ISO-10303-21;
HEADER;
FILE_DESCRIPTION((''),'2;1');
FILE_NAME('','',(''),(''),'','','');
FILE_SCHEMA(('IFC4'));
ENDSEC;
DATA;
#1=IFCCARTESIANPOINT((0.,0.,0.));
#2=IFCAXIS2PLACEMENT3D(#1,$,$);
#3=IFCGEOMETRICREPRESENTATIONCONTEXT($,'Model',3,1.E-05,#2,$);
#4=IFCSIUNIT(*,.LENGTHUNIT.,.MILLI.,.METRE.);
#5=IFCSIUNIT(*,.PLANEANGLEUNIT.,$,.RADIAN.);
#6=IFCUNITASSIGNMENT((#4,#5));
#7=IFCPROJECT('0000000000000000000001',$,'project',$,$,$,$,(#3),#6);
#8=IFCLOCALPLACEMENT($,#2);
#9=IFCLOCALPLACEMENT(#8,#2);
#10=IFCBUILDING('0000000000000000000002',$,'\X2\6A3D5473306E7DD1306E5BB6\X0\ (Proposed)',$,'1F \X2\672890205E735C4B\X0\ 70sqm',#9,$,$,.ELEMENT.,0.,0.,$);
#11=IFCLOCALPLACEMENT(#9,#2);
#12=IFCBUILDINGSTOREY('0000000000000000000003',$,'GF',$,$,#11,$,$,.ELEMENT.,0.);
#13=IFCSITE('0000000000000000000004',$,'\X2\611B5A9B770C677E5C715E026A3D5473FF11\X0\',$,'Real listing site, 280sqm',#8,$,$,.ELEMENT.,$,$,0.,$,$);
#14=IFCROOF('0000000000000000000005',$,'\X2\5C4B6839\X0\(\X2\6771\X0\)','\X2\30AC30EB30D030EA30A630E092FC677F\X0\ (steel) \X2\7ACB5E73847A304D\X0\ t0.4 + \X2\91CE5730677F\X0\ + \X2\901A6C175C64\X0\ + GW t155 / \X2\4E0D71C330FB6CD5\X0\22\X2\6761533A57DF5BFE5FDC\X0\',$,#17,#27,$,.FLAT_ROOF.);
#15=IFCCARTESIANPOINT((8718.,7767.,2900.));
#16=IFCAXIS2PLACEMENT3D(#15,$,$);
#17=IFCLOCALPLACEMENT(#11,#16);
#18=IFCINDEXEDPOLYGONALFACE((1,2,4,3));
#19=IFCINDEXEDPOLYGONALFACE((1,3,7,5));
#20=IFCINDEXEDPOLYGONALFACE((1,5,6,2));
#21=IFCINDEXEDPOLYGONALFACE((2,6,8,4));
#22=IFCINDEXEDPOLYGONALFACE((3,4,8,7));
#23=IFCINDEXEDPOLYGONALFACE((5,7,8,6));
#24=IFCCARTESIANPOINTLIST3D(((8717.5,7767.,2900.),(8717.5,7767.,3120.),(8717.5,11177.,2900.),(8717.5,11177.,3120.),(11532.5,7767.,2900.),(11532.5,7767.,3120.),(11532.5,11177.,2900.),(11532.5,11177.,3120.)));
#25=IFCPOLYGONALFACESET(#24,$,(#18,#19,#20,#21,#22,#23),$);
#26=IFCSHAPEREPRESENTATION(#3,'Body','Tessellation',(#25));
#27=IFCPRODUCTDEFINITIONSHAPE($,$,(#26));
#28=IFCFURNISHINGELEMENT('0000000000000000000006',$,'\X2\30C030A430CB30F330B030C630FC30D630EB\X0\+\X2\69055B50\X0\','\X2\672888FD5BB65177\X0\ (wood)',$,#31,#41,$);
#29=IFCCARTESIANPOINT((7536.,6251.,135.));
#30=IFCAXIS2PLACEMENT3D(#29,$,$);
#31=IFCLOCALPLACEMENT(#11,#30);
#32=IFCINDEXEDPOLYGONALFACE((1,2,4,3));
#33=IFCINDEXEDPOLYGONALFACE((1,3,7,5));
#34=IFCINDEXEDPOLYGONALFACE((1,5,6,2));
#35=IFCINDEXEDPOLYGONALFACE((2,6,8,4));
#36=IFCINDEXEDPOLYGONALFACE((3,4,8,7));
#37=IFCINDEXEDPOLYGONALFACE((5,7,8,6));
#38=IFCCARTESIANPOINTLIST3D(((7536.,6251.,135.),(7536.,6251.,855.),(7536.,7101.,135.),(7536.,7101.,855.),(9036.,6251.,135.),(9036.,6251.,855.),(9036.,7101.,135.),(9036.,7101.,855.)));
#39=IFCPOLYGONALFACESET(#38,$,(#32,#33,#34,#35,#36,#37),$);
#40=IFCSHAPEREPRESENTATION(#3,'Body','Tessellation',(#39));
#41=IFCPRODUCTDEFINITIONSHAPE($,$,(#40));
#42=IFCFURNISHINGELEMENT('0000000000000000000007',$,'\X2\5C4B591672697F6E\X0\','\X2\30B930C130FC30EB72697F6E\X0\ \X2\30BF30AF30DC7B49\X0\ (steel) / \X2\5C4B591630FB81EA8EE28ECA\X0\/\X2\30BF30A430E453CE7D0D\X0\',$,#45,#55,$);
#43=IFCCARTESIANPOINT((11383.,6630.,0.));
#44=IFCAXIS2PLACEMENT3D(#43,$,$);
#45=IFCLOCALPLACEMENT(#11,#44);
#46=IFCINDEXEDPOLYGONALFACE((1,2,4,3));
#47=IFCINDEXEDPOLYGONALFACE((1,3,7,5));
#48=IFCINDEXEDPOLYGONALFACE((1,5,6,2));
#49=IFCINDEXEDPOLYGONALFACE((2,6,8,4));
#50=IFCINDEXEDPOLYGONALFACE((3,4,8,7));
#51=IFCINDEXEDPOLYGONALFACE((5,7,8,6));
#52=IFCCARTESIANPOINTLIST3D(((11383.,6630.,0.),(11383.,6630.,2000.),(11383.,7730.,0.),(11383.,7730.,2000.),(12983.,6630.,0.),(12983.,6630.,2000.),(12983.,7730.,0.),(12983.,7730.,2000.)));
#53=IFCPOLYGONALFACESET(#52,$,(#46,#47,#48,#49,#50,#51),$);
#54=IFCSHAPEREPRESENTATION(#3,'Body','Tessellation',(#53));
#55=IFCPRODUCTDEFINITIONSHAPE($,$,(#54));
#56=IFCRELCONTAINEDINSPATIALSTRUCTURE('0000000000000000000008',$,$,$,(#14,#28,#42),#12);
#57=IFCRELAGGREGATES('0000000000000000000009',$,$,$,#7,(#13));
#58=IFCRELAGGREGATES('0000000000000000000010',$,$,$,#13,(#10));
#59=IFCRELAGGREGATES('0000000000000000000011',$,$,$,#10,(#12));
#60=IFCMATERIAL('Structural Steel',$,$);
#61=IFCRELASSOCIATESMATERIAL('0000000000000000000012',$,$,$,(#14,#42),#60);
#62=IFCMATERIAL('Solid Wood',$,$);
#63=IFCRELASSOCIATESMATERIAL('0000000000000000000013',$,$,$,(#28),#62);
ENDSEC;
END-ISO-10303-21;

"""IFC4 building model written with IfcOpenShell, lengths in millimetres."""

from ifc_helpers import new_model, si_unit, frame, frame_2d, origin, place, context, project, spatial, rectangle, extrude, material, element, save


model = new_model("IFC4")

# Units and contexts
model_context = context("Model", 3, precision=1e-05, world=origin())
ifc_project = project(units=[si_unit("LENGTHUNIT", "METRE", prefix="MILLI"), si_unit("PLANEANGLEUNIT", "RADIAN")], contexts=[model_context])

# Site, building, storey
site_placement = place(None, origin())
site = spatial("IfcSite", under=ifc_project, at=site_placement, Name="愛媛県松山市樽味１", ObjectType="Real listing site, 280sqm", CompositionType="ELEMENT", RefElevation=0.0)
building_placement = place(site_placement, origin())
building = spatial("IfcBuilding", under=site, at=building_placement, Name="樽味の緑の家 (Proposed)", ObjectType="1F 木造平屋 70sqm", CompositionType="ELEMENT", ElevationOfRefHeight=0.0, ElevationOfTerrain=0.0)
storey_placement = place(building_placement, origin())
storey = spatial("IfcBuildingStorey", under=building, at=storey_placement, Name="GF", CompositionType="ELEMENT", Elevation=0.0)

# Shared definitions
ifc_material_1 = material(Name="Solid Wood")

# Roof
ifc_material_2 = material(Name="Structural Steel")
roof_1_placement = place(storey_placement, frame((8718.0, 7767.0, 2900.0)))
element("IfcRoof", 1, at=roof_1_placement, inside=storey, material=ifc_material_2, Name="屋根(東)", Description="ガルバリウム鋼板 (steel) 立平葺き t0.4 + 野地板 + 通気層 + GW t155 / 不燃・法22条区域対応", PredefinedType="FLAT_ROOF", context=model_context, shape_type="SweptSolid", body=[
    extrude(rectangle(XDim=2815.0, YDim=3410.0, at=frame_2d((1407.0, 1705.0))), frame((8718.0, 7767.0, 2900.0)), (0.0, 0.0, 1.0), 220.0),
])

# Furnishing elements
furnishing_1_placement = place(storey_placement, frame((7536.0, 6251.0, 135.0)))
element("IfcFurnishingElement", 2, at=furnishing_1_placement, inside=storey, material=ifc_material_1, Name="ダイニングテーブル+椅子", Description="木製家具 (wood)", context=model_context, shape_type="SweptSolid", body=[
    extrude(rectangle(XDim=1500.0, YDim=850.0, at=frame_2d((750.0, 425.0))), frame((7536.0, 6251.0, 135.0)), (0.0, 0.0, 1.0), 720.0),
])
furnishing_2_placement = place(storey_placement, frame((11383.0, 6630.0, 0.0)))
element("IfcFurnishingElement", 3, at=furnishing_2_placement, inside=storey, material=ifc_material_2, Name="屋外物置", Description="スチール物置 タクボ等 (steel) / 屋外・自転車/タイヤ収納", context=model_context, shape_type="SweptSolid", body=[
    extrude(rectangle(XDim=1600.0, YDim=1100.0, at=frame_2d((800.0, 550.0))), frame((11383.0, 6630.0, 0.0)), (0.0, 0.0, 1.0), 2000.0),
])

save(model, "model.ifc")
